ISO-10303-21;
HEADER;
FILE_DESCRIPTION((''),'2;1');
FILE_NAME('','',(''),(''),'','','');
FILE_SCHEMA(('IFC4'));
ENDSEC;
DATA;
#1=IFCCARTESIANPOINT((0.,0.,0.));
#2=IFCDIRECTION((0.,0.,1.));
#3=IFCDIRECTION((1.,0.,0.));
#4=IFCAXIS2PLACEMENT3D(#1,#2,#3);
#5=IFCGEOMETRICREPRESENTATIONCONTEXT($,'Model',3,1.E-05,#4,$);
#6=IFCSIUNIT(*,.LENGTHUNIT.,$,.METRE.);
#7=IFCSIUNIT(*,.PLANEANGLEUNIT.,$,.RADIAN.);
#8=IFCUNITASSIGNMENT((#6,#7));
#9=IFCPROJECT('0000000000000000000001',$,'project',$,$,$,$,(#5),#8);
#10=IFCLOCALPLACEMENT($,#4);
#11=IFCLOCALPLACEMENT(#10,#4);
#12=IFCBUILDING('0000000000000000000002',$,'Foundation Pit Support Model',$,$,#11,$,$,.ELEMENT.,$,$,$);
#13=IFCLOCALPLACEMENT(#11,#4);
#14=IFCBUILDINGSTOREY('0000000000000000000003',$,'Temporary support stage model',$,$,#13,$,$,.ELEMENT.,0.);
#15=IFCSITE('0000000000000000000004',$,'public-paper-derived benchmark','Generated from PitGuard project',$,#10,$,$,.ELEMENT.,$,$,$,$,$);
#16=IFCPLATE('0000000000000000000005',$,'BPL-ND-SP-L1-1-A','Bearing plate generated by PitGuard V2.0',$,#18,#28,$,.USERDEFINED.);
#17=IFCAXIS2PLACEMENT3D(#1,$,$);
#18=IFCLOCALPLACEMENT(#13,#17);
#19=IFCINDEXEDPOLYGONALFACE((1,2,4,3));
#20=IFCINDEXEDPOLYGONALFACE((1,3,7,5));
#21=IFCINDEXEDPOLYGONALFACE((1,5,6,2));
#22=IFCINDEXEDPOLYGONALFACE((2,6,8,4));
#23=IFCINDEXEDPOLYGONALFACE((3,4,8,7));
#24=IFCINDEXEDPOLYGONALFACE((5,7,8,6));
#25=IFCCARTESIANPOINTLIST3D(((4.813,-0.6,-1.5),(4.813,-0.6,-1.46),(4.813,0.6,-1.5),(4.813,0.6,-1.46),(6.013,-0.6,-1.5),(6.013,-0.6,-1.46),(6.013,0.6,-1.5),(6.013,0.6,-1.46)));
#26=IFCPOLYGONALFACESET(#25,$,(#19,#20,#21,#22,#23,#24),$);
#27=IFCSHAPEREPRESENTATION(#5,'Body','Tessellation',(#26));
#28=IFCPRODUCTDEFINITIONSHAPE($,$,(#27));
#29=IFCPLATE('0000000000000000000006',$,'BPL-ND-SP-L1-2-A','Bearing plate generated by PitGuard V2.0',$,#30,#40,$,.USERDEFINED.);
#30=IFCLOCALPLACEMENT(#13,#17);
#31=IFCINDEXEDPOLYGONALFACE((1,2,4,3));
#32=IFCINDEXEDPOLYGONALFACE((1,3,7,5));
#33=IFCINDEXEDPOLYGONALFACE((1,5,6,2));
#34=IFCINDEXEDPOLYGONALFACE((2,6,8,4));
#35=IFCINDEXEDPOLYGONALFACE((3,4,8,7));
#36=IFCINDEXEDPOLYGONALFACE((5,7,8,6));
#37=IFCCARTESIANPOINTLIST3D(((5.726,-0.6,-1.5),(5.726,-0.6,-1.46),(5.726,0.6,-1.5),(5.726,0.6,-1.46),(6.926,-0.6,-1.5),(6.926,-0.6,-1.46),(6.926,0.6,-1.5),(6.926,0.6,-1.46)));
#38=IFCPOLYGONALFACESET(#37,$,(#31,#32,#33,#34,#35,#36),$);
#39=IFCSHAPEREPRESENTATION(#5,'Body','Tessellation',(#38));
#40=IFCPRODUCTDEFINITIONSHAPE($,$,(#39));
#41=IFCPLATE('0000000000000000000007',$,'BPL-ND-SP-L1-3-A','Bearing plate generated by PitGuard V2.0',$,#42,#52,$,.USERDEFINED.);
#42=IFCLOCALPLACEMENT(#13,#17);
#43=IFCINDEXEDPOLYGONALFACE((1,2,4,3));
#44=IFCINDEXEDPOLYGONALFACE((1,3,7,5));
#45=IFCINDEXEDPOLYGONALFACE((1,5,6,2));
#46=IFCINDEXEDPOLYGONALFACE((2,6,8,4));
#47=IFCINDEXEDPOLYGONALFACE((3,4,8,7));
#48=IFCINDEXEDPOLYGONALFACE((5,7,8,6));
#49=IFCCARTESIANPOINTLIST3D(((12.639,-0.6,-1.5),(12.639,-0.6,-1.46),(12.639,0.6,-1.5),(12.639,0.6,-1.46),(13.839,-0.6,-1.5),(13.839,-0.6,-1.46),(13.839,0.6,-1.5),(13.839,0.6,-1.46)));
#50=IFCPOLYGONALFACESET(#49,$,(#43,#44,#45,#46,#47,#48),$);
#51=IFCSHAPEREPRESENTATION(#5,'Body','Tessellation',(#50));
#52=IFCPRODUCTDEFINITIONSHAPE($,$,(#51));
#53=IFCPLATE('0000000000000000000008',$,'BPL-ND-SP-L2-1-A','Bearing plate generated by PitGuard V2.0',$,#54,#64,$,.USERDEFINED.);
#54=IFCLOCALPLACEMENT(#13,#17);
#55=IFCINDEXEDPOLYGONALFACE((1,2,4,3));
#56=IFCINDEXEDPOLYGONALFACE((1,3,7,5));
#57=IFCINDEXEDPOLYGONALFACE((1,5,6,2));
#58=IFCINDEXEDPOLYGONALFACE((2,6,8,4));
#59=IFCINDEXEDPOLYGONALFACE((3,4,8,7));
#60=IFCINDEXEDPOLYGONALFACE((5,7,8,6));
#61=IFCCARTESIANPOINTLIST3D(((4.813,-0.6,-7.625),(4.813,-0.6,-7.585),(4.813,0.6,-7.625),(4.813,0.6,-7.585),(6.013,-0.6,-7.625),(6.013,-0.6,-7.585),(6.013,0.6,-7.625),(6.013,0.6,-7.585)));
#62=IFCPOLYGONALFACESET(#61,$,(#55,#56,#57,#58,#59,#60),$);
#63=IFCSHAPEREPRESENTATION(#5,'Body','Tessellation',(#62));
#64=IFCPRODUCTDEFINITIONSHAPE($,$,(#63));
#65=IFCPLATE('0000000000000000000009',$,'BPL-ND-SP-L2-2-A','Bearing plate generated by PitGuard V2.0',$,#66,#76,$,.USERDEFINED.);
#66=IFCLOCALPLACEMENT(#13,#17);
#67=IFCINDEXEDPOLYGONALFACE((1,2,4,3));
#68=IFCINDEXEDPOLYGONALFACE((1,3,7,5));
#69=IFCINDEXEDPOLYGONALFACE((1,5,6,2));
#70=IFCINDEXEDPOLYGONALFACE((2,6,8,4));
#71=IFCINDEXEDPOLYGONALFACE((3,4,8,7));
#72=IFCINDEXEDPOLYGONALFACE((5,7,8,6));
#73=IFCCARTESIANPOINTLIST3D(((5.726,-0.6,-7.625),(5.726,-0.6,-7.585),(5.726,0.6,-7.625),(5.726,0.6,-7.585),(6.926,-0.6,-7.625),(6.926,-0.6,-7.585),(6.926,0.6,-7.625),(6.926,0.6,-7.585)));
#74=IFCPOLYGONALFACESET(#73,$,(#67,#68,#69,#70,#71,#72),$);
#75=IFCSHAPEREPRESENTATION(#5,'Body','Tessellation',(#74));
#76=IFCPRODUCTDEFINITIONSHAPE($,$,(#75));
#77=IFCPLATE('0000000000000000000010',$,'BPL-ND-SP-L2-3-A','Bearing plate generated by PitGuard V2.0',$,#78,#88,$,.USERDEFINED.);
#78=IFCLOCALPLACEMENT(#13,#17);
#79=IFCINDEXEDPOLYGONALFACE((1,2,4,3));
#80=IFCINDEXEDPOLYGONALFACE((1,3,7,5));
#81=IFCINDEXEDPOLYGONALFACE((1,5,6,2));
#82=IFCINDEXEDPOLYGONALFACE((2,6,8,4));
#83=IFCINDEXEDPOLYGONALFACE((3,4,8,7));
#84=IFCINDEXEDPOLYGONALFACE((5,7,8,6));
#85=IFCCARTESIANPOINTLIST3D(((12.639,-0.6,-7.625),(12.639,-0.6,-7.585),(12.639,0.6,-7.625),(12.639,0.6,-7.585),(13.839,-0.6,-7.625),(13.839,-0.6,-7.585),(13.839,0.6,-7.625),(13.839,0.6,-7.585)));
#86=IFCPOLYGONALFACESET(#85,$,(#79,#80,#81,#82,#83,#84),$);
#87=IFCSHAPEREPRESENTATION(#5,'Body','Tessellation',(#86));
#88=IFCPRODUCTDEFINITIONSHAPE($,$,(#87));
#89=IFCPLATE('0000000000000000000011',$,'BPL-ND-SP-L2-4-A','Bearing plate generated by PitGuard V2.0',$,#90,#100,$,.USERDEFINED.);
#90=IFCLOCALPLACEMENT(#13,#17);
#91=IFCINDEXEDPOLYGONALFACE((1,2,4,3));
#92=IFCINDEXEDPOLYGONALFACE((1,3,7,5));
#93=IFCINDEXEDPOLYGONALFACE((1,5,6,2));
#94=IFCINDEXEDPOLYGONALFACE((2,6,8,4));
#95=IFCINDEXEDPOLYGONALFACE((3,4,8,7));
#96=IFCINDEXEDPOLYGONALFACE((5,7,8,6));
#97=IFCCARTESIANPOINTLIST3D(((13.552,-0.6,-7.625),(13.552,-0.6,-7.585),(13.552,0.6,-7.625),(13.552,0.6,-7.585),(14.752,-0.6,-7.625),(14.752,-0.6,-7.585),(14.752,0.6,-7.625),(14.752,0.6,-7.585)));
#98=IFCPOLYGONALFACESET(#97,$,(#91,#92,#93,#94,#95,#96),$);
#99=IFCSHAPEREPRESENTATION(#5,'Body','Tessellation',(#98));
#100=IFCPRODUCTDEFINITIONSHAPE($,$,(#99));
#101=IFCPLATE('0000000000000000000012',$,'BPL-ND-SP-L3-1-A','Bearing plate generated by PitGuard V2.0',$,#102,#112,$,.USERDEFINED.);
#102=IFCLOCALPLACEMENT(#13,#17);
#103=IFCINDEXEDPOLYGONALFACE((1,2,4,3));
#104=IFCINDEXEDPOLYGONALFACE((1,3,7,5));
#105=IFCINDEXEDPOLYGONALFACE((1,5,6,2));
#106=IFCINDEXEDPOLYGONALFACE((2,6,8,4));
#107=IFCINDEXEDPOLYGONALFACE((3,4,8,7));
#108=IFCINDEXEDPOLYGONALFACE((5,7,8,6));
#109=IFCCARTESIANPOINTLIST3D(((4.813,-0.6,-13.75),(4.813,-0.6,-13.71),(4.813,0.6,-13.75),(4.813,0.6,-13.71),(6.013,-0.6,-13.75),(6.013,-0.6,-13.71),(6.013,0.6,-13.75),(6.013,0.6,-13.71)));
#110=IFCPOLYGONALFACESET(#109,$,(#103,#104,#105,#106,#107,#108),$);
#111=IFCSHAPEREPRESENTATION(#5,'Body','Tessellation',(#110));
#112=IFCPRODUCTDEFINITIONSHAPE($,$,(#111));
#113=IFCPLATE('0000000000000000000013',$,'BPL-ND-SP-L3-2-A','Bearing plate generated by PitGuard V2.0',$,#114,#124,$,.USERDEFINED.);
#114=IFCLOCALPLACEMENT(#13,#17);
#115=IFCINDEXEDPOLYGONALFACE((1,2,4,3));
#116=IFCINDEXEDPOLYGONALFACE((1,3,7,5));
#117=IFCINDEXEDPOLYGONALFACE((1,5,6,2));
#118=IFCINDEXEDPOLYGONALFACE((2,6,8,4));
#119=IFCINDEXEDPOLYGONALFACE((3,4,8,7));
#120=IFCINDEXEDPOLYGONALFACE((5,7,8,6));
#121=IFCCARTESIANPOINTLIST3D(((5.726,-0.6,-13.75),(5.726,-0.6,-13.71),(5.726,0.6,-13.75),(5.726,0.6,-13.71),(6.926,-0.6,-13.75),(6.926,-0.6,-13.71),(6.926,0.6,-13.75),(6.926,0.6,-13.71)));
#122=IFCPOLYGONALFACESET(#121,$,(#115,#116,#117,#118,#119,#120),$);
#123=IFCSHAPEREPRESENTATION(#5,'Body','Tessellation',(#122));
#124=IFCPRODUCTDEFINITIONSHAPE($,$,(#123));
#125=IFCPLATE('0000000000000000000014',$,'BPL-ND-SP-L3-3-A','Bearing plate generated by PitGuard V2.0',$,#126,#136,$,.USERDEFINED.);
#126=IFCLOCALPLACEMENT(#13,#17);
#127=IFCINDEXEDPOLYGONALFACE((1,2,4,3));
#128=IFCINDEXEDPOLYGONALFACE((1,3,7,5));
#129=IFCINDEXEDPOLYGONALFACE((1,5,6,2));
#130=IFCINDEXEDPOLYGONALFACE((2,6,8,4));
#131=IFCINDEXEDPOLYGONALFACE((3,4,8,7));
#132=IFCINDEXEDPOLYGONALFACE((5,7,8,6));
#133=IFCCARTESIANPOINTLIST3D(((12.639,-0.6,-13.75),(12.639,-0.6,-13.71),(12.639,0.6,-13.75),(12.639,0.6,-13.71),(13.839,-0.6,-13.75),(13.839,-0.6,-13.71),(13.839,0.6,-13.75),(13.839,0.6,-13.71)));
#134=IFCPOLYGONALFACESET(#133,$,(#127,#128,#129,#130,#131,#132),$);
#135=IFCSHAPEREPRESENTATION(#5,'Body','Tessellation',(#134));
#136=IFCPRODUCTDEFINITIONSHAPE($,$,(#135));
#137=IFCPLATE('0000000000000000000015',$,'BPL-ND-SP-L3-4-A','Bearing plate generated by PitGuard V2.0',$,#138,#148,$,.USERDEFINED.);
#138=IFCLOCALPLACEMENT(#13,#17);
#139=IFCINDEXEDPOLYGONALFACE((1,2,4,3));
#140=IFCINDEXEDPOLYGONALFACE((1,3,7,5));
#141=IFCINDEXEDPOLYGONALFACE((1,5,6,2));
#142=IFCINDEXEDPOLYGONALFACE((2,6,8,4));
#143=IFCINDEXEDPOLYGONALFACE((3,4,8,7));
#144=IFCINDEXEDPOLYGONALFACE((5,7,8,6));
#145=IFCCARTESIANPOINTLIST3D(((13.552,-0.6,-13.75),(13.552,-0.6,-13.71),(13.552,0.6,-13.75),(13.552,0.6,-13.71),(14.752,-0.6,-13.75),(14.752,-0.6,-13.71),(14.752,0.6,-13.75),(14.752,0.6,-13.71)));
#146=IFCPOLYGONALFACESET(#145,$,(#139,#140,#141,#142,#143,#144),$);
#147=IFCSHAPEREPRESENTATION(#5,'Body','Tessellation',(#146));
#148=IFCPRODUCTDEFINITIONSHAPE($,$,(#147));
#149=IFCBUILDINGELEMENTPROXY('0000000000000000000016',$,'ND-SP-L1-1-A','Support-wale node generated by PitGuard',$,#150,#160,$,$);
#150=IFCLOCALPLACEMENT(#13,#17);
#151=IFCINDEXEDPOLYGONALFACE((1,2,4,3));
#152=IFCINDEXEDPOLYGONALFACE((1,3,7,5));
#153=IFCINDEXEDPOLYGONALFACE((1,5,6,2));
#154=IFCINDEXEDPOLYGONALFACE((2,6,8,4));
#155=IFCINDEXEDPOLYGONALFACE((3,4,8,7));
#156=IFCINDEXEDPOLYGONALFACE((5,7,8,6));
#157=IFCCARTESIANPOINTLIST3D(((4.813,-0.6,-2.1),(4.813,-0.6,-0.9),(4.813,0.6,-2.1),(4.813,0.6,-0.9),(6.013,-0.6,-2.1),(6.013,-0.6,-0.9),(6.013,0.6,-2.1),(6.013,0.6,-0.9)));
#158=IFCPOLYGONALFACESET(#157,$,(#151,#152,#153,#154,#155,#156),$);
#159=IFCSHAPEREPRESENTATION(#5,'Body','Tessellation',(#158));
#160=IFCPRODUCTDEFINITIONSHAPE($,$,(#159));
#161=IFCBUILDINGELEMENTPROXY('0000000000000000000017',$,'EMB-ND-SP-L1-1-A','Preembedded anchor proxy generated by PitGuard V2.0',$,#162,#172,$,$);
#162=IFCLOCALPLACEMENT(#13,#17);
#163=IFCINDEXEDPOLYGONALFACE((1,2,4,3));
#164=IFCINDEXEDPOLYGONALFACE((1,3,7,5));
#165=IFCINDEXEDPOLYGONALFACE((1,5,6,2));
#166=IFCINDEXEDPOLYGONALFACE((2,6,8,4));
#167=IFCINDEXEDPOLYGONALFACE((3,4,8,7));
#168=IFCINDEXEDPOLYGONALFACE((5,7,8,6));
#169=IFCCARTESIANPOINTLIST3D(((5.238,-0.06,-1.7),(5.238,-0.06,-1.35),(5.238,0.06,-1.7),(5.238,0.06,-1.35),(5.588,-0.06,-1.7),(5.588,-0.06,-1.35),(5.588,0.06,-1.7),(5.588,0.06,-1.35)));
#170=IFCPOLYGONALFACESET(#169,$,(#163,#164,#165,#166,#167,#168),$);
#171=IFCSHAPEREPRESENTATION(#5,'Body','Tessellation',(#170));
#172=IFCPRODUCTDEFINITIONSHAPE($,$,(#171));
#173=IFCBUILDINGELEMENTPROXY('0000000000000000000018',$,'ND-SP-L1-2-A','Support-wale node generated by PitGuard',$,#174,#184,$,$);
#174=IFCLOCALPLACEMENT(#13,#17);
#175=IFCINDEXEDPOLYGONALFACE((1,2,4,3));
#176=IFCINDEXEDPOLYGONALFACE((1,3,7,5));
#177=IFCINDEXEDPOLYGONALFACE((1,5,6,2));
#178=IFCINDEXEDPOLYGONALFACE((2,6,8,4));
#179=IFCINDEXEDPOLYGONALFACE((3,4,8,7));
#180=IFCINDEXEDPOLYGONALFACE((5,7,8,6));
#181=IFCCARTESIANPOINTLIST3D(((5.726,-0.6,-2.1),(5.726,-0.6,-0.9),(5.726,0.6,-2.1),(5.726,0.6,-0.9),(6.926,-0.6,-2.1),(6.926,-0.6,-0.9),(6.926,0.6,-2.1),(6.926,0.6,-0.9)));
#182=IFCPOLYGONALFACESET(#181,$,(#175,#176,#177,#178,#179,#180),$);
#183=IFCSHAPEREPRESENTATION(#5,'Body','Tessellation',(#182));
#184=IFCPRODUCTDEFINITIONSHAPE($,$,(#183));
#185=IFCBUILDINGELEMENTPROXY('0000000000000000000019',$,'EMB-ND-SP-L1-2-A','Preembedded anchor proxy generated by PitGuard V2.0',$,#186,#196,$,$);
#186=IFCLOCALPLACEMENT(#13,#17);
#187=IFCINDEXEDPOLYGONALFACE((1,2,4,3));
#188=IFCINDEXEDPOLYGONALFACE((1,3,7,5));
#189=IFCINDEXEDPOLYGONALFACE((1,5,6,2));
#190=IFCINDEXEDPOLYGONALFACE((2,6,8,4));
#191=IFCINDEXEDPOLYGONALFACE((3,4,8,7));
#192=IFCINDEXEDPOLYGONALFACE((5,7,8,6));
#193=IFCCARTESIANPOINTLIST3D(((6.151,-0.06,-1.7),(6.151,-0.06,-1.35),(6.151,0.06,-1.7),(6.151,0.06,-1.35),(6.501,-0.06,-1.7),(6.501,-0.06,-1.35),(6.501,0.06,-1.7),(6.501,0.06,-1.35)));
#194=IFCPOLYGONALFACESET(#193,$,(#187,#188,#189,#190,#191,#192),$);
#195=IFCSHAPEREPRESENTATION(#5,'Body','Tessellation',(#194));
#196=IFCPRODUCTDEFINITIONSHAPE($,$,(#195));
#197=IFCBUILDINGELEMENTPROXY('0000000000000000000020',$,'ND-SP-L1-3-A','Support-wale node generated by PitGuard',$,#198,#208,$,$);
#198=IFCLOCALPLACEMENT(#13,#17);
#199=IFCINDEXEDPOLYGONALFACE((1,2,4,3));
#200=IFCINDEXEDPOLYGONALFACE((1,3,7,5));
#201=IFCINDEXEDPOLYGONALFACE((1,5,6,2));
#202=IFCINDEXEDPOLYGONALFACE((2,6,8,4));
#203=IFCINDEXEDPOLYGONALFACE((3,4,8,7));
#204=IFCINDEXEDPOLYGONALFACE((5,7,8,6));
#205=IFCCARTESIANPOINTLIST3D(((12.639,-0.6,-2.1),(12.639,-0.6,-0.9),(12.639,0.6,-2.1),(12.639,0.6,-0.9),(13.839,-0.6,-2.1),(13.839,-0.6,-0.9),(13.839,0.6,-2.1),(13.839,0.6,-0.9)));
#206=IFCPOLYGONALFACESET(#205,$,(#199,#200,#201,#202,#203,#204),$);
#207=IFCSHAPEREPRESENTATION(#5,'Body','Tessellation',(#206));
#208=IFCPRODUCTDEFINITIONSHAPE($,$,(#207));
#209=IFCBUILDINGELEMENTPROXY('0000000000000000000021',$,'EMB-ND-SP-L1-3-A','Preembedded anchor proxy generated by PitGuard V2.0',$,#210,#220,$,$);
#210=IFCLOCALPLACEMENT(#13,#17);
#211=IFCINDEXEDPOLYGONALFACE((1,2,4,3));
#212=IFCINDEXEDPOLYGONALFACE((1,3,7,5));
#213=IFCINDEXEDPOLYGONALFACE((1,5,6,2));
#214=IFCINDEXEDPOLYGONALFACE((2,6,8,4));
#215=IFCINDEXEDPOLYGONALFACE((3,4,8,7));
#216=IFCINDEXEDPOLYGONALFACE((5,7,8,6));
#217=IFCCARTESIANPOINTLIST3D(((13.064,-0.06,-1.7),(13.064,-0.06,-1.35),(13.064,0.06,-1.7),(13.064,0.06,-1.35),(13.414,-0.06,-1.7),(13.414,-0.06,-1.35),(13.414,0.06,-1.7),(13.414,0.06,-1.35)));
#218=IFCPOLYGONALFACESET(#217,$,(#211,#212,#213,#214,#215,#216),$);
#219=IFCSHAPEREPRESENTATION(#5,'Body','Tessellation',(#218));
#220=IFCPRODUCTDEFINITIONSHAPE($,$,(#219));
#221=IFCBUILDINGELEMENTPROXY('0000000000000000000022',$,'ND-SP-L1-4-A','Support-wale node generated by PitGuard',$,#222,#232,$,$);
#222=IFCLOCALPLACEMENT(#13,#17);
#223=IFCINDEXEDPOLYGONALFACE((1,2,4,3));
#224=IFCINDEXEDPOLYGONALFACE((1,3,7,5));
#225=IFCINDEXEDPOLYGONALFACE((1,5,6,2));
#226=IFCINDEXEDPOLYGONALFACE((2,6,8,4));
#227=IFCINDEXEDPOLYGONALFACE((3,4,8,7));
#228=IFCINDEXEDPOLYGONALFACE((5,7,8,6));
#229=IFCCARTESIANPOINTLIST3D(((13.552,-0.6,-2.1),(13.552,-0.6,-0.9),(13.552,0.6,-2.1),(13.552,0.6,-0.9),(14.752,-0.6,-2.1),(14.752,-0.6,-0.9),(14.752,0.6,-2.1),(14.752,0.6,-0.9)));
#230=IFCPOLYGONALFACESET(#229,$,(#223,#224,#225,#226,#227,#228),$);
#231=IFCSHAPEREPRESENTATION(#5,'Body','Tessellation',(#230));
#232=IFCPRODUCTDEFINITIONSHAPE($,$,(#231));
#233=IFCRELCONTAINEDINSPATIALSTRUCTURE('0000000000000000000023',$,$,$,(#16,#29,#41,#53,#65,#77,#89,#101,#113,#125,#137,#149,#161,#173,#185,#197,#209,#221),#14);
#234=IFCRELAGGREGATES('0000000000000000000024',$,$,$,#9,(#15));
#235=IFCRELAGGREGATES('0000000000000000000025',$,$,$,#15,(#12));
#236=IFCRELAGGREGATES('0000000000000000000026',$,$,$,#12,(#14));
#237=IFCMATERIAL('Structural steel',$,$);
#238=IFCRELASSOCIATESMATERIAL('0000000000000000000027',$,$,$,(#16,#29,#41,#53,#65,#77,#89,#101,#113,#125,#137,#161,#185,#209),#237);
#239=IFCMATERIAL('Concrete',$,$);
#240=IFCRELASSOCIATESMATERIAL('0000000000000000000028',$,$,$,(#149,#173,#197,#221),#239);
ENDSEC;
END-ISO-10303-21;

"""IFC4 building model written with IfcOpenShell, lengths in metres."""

from ifc_helpers import new_model, si_unit, frame, origin_with_axes, origin_2d, place, context, project, spatial, rectangle, extrude, material, element, save


model = new_model("IFC4")

# Units and contexts
model_context = context("Model", 3, precision=1e-05, world=origin_with_axes())
ifc_project = project(units=[si_unit("LENGTHUNIT", "METRE"), si_unit("PLANEANGLEUNIT", "RADIAN")], contexts=[model_context])

# Site, building, storey
site_placement = place(None, origin_with_axes())
site = spatial("IfcSite", under=ifc_project, at=site_placement, Name="public-paper-derived benchmark", Description="Generated from PitGuard project", CompositionType="ELEMENT")
building_placement = place(site_placement, origin_with_axes())
building = spatial("IfcBuilding", under=site, at=building_placement, Name="Foundation Pit Support Model", CompositionType="ELEMENT")
storey_placement = place(building_placement, origin_with_axes())
storey = spatial("IfcBuildingStorey", under=building, at=storey_placement, Name="Temporary support stage model", CompositionType="ELEMENT", Elevation=0.0)

# Plates
ifc_material_1 = material(Name="Structural steel")
for number, where, z_axis, x_axis, name in (
    (1, (5.413, 0.0, -1.5), (0.0, 0.0, 1.0), (1.0, 0.0, 0.0), "BPL-ND-SP-L1-1-A"),
    (2, (6.326, 0.0, -1.5), (0.0, 0.0, 1.0), (1.0, 0.0, 0.0), "BPL-ND-SP-L1-2-A"),
    (3, (13.239, 0.0, -1.5), (0.0, 0.0, 1.0), (1.0, 0.0, 0.0), "BPL-ND-SP-L1-3-A"),
    (4, (5.413, 0.0, -7.625), (0.0, 0.0, 1.0), (1.0, 0.0, 0.0), "BPL-ND-SP-L2-1-A"),
    (5, (6.326, 0.0, -7.625), (0.0, 0.0, 1.0), (1.0, 0.0, 0.0), "BPL-ND-SP-L2-2-A"),
    (6, (13.239, 0.0, -7.625), (0.0, 0.0, 1.0), (1.0, 0.0, 0.0), "BPL-ND-SP-L2-3-A"),
    (7, (14.152, 0.0, -7.625), (0.0, 0.0, 1.0), (1.0, 0.0, 0.0), "BPL-ND-SP-L2-4-A"),
    (8, (5.413, 0.0, -13.75), (0.0, 0.0, 1.0), (1.0, 0.0, 0.0), "BPL-ND-SP-L3-1-A"),
    (9, (6.326, 0.0, -13.75), (0.0, 0.0, 1.0), (1.0, 0.0, 0.0), "BPL-ND-SP-L3-2-A"),
    (10, (13.239, 0.0, -13.75), (0.0, 0.0, 1.0), (1.0, 0.0, 0.0), "BPL-ND-SP-L3-3-A"),
    (11, (14.152, 0.0, -13.75), (0.0, 0.0, 1.0), (1.0, 0.0, 0.0), "BPL-ND-SP-L3-4-A"),
):
    element("IfcPlate", number, at=place(storey_placement, frame(where, z_axis=z_axis, x_axis=x_axis)), inside=storey, material=ifc_material_1, Name=name, Description="Bearing plate generated by PitGuard V2.0", PredefinedType="USERDEFINED", context=model_context, shape_type="SweptSolid", body=[
        extrude(rectangle(XDim=1.2, YDim=1.2, at=origin_2d()), origin_with_axes(), (0.0, 0.0, 1.0), 0.04),
    ])

# Building element proxies
ifc_material_2 = material(Name="Concrete")
proxy_1_placement = place(storey_placement, frame((5.413, 0.0, -2.1), z_axis=(0.0, 0.0, 1.0), x_axis=(1.0, 0.0, 0.0)))
element("IfcBuildingElementProxy", 12, at=proxy_1_placement, inside=storey, material=ifc_material_2, Name="ND-SP-L1-1-A", Description="Support-wale node generated by PitGuard", context=model_context, shape_type="SweptSolid", body=[
    extrude(rectangle(XDim=1.2, YDim=1.2, at=origin_2d()), origin_with_axes(), (0.0, 0.0, 1.0), 1.2),
])
proxy_2_placement = place(storey_placement, frame((5.413, 0.0, -1.7), z_axis=(0.0, 0.0, 1.0), x_axis=(1.0, 0.0, 0.0)))
element("IfcBuildingElementProxy", 13, at=proxy_2_placement, inside=storey, material=ifc_material_1, Name="EMB-ND-SP-L1-1-A", Description="Preembedded anchor proxy generated by PitGuard V2.0", context=model_context, shape_type="SweptSolid", body=[
    extrude(rectangle(XDim=0.35, YDim=0.12, at=origin_2d()), origin_with_axes(), (0.0, 0.0, 1.0), 0.35),
])
proxy_3_placement = place(storey_placement, frame((6.326, 0.0, -2.1), z_axis=(0.0, 0.0, 1.0), x_axis=(1.0, 0.0, 0.0)))
element("IfcBuildingElementProxy", 14, at=proxy_3_placement, inside=storey, material=ifc_material_2, Name="ND-SP-L1-2-A", Description="Support-wale node generated by PitGuard", context=model_context, shape_type="SweptSolid", body=[
    extrude(rectangle(XDim=1.2, YDim=1.2, at=origin_2d()), origin_with_axes(), (0.0, 0.0, 1.0), 1.2),
])
proxy_4_placement = place(storey_placement, frame((6.326, 0.0, -1.7), z_axis=(0.0, 0.0, 1.0), x_axis=(1.0, 0.0, 0.0)))
element("IfcBuildingElementProxy", 15, at=proxy_4_placement, inside=storey, material=ifc_material_1, Name="EMB-ND-SP-L1-2-A", Description="Preembedded anchor proxy generated by PitGuard V2.0", context=model_context, shape_type="SweptSolid", body=[
    extrude(rectangle(XDim=0.35, YDim=0.12, at=origin_2d()), origin_with_axes(), (0.0, 0.0, 1.0), 0.35),
])
proxy_5_placement = place(storey_placement, frame((13.239, 0.0, -2.1), z_axis=(0.0, 0.0, 1.0), x_axis=(1.0, 0.0, 0.0)))
element("IfcBuildingElementProxy", 16, at=proxy_5_placement, inside=storey, material=ifc_material_2, Name="ND-SP-L1-3-A", Description="Support-wale node generated by PitGuard", context=model_context, shape_type="SweptSolid", body=[
    extrude(rectangle(XDim=1.2, YDim=1.2, at=origin_2d()), origin_with_axes(), (0.0, 0.0, 1.0), 1.2),
])
proxy_6_placement = place(storey_placement, frame((13.239, 0.0, -1.7), z_axis=(0.0, 0.0, 1.0), x_axis=(1.0, 0.0, 0.0)))
element("IfcBuildingElementProxy", 17, at=proxy_6_placement, inside=storey, material=ifc_material_1, Name="EMB-ND-SP-L1-3-A", Description="Preembedded anchor proxy generated by PitGuard V2.0", context=model_context, shape_type="SweptSolid", body=[
    extrude(rectangle(XDim=0.35, YDim=0.12, at=origin_2d()), origin_with_axes(), (0.0, 0.0, 1.0), 0.35),
])
for number, where, z_axis, x_axis, name in (
    (18, (14.152, 0.0, -2.1), (0.0, 0.0, 1.0), (1.0, 0.0, 0.0), "ND-SP-L1-4-A"),
):
    element("IfcBuildingElementProxy", number, at=place(storey_placement, frame(where, z_axis=z_axis, x_axis=x_axis)), inside=storey, material=ifc_material_2, Name=name, Description="Support-wale node generated by PitGuard", context=model_context, shape_type="SweptSolid", body=[
        extrude(rectangle(XDim=1.2, YDim=1.2, at=origin_2d()), origin_with_axes(), (0.0, 0.0, 1.0), 1.2),
    ])

save(model, "model.ifc")
